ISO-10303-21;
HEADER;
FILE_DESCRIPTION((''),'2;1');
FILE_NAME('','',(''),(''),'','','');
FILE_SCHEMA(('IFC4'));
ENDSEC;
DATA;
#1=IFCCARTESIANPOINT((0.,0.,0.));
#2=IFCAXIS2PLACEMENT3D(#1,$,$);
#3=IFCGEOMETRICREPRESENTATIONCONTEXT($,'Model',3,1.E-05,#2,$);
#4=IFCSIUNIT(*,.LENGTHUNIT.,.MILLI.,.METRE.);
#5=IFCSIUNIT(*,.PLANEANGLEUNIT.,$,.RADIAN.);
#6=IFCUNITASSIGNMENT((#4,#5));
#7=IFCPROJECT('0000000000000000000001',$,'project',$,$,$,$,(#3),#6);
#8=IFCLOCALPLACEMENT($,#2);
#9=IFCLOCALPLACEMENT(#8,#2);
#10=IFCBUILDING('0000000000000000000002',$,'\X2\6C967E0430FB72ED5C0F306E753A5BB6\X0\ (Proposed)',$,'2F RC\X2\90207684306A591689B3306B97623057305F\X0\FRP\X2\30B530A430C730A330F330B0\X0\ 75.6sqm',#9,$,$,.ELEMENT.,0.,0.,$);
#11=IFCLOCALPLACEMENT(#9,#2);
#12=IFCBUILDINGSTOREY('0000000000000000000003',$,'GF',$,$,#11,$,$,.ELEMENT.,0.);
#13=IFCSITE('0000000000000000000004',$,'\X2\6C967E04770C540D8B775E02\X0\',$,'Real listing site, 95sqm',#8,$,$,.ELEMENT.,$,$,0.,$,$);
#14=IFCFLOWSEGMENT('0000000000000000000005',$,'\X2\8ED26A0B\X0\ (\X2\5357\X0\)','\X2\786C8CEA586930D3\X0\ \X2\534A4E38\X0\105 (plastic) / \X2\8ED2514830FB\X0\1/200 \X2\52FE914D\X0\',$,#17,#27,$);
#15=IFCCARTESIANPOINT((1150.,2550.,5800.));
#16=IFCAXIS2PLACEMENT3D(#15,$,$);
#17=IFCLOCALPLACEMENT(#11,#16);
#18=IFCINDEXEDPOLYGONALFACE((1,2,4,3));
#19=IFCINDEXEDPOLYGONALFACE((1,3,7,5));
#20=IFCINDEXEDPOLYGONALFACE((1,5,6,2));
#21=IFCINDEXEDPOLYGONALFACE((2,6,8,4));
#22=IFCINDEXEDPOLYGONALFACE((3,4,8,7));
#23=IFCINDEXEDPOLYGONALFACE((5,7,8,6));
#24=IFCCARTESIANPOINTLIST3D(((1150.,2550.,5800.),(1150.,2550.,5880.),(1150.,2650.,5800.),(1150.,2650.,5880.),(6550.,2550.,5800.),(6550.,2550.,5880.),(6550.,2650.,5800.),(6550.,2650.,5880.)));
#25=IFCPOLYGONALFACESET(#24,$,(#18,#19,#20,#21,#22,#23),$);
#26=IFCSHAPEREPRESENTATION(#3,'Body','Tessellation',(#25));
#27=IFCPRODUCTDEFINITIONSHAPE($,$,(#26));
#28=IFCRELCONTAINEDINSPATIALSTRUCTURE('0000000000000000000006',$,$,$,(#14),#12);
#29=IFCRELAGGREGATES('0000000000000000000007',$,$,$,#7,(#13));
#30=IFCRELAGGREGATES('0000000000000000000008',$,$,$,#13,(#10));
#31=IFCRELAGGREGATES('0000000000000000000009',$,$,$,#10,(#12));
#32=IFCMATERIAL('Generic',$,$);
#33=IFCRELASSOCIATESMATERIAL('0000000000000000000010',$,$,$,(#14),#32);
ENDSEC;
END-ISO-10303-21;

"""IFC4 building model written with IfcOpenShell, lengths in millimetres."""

from ifc_helpers import new_model, si_unit, frame, frame_2d, origin, place, context, project, spatial, rectangle, extrude, material, element, save


model = new_model("IFC4")

# Units and contexts
model_context = context("Model", 3, precision=1e-05, world=origin())
ifc_project = project(units=[si_unit("LENGTHUNIT", "METRE", prefix="MILLI"), si_unit("PLANEANGLEUNIT", "RADIAN")], contexts=[model_context])

# Site, building, storey
site_placement = place(None, origin())
site = spatial("IfcSite", under=ifc_project, at=site_placement, Name="沖縄県名護市", ObjectType="Real listing site, 95sqm", CompositionType="ELEMENT", RefElevation=0.0)
building_placement = place(site_placement, origin())
building = spatial("IfcBuilding", under=site, at=building_placement, Name="沖縄・狭小の町家 (Proposed)", ObjectType="2F RC造的な外観に面したFRPサイディング 75.6sqm", CompositionType="ELEMENT", ElevationOfRefHeight=0.0, ElevationOfTerrain=0.0)
storey_placement = place(building_placement, origin())
storey = spatial("IfcBuildingStorey", under=building, at=storey_placement, Name="GF", CompositionType="ELEMENT", Elevation=0.0)

# Flow segment
ifc_material_1 = material(Name="Generic")
flow_segment_placement = place(storey_placement, frame((1150.0, 2550.0, 5800.0)))
element("IfcFlowSegment", 1, at=flow_segment_placement, inside=storey, material=ifc_material_1, Name="軒樋 (南)", Description="硬質塩ビ 半丸105 (plastic) / 軒先・1/200 勾配", context=model_context, shape_type="SweptSolid", body=[
    extrude(rectangle(XDim=5400.0, YDim=100.0, at=frame_2d((2700.0, 50.0))), frame((1150.0, 2550.0, 5800.0)), (0.0, 0.0, 1.0), 80.0),
])

save(model, "model.ifc")
